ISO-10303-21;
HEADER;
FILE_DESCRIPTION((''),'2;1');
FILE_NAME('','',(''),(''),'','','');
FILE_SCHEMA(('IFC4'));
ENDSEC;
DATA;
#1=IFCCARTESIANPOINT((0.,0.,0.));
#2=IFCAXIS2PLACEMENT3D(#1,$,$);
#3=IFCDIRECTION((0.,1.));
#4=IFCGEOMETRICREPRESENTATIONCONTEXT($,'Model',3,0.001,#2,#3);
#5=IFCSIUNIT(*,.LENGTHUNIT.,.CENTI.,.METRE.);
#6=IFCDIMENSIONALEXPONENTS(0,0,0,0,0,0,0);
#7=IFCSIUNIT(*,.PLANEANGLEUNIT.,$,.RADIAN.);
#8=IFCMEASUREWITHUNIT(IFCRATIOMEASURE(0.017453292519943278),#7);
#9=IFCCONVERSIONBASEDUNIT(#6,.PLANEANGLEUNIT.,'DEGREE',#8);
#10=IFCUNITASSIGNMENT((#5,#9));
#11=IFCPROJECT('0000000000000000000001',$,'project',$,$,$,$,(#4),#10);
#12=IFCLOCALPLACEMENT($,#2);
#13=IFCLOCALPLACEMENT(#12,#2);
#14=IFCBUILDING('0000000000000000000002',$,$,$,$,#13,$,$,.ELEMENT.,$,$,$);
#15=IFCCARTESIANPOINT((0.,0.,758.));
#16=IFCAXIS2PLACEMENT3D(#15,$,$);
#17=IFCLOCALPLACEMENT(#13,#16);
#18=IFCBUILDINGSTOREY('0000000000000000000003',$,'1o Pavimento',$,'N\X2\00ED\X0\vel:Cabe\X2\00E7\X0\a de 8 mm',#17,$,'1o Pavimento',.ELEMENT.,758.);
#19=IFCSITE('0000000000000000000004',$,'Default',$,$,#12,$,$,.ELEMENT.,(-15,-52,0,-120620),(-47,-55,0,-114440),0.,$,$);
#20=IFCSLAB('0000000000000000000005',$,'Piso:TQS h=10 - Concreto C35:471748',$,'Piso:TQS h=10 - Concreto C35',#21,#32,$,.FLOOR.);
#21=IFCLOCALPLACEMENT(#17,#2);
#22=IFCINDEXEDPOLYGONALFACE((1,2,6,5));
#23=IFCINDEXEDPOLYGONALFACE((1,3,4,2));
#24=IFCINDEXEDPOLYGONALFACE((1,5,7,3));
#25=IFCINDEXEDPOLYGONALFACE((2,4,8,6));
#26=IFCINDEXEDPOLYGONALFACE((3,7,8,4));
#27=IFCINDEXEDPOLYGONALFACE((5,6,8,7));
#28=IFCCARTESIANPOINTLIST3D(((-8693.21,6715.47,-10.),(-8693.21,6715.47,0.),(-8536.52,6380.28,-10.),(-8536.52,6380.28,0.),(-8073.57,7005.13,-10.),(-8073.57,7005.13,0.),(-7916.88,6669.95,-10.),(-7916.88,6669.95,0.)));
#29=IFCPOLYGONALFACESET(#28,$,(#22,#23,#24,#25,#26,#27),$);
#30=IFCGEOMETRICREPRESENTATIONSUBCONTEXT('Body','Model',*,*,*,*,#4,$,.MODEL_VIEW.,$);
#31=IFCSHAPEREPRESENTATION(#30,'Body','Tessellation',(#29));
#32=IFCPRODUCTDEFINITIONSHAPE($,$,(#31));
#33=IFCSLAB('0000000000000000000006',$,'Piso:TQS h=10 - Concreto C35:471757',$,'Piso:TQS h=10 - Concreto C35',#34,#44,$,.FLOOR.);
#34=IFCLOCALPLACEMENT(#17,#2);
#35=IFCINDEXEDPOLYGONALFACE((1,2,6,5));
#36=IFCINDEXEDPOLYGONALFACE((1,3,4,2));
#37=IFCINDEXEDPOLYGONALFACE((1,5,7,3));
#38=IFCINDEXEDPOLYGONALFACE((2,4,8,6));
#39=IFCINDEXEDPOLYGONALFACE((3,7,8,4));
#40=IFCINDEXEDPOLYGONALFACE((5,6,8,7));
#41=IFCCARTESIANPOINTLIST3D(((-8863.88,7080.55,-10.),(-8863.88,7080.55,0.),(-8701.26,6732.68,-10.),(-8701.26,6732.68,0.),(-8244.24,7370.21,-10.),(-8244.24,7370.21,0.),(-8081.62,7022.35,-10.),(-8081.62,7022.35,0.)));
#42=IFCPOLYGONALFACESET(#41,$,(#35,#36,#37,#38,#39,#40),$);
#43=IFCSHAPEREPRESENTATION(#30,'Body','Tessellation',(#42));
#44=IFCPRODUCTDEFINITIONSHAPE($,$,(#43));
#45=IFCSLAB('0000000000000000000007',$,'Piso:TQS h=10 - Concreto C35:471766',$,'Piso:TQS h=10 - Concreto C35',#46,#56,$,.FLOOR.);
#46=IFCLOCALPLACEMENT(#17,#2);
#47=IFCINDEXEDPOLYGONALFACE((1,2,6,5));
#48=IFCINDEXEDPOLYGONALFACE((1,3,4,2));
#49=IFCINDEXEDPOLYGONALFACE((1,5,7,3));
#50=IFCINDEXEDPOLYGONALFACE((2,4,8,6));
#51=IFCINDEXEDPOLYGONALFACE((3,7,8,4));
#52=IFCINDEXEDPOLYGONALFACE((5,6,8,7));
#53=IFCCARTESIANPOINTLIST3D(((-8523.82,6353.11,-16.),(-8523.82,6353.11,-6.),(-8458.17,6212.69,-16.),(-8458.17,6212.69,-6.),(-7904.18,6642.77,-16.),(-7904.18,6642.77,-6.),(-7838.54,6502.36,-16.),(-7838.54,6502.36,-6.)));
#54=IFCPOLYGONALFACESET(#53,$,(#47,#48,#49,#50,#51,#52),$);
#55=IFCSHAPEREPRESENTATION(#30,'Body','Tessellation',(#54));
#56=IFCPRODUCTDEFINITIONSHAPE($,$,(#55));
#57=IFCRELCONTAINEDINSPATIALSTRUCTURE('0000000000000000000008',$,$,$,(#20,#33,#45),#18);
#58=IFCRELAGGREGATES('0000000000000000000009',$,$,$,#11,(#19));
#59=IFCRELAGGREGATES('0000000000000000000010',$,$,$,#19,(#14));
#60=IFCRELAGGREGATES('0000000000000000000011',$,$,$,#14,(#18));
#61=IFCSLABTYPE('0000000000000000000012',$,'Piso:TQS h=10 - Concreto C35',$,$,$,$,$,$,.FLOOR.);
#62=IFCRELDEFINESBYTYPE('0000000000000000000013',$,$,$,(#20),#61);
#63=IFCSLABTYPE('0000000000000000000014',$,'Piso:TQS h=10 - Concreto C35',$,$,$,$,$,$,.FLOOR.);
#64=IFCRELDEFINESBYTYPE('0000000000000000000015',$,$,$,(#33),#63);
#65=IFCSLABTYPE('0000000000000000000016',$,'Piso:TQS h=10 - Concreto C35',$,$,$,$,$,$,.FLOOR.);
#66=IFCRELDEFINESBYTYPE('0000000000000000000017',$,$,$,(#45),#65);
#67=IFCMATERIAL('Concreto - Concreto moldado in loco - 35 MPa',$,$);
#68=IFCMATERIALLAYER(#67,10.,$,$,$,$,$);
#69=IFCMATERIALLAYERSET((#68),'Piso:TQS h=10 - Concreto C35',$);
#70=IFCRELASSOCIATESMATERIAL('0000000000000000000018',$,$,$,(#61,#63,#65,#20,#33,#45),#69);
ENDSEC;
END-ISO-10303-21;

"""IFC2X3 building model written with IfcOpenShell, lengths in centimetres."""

from ifc_helpers import new_model, entity, si_unit, converted_unit, direction, frame, frame_2d, origin, place, context, subcontext, project, spatial, rectangle, extrude, material, layer, layer_set, layer_usage, type_object, element, save


model = new_model("IFC2X3")

# Units and contexts
model_context = context("Model", 3, precision=0.001, world=origin(), true_north=direction((0.0, 1.0)))
body_context = subcontext(model_context, "Body", "Model", "MODEL_VIEW")
ifc_project = project(units=[si_unit("LENGTHUNIT", "METRE", prefix="CENTI"), converted_unit("PLANEANGLEUNIT", "DEGREE", entity("IfcRatioMeasure", 0.017453292519943278), si_unit("PLANEANGLEUNIT", "RADIAN"), dimensions=[0, 0, 0, 0, 0, 0, 0])], contexts=[model_context])

# Site, building, storey
site_placement = place(None, origin())
site = spatial("IfcSite", under=ifc_project, at=site_placement, Name="Default", CompositionType="ELEMENT", RefLatitude=(-15, -52, 0, -120620), RefLongitude=(-47, -55, 0, -114440), RefElevation=0.0)
building_placement = place(site_placement, origin())
building = spatial("IfcBuilding", under=site, at=building_placement, CompositionType="ELEMENT")
storey_placement = place(building_placement, frame((0.0, 0.0, 758.0)))
storey = spatial("IfcBuildingStorey", under=building, at=storey_placement, Name="1o Pavimento", ObjectType="Nível:Cabeça de 8 mm", LongName="1o Pavimento", CompositionType="ELEMENT", Elevation=758.0)

# Shared definitions
ifc_material = material(Name="Concreto - Concreto moldado in loco - 35 MPa")

# Slabs
ifc_layer_1 = layer(ifc_material, 10.0)
ifc_layer_set_1 = layer_set([ifc_layer_1], Name="Piso:TQS h=10 - Concreto C35")
ifc_layer_usage_1 = layer_usage(ifc_layer_set_1, "AXIS3", "POSITIVE", 0.0)
slab_type_1 = type_object("IfcSlabType", Name="Piso:TQS h=10 - Concreto C35", PredefinedType="FLOOR", material=ifc_layer_set_1)
slab_1_placement = place(storey_placement, origin())
element("IfcSlab", 1, at=slab_1_placement, inside=storey, type_object=slab_type_1, material=ifc_layer_usage_1, Name="Piso:TQS h=10 - Concreto C35:471748", ObjectType="Piso:TQS h=10 - Concreto C35", PredefinedType="FLOOR", context=body_context, shape_type="SweptSolid", body=[
    extrude(rectangle(XDim=684.0, YDim=370.0, at=frame_2d((0.0, 0.0), x_axis=(1.0, 0.0))), frame((-8305.05, 6692.71, 0.0), z_axis=(0.0, 0.0, -1.0), x_axis=(0.905902, 0.423488, 0.0)), (0.0, 0.0, 1.0), 10.0),
])
ifc_layer_usage_2 = layer_usage(ifc_layer_set_1, "AXIS3", "POSITIVE", 0.0)
slab_type_2 = type_object("IfcSlabType", Name="Piso:TQS h=10 - Concreto C35", PredefinedType="FLOOR", material=ifc_layer_set_1)
slab_2_placement = place(storey_placement, origin())
element("IfcSlab", 2, at=slab_2_placement, inside=storey, type_object=slab_type_2, material=ifc_layer_usage_2, Name="Piso:TQS h=10 - Concreto C35:471757", ObjectType="Piso:TQS h=10 - Concreto C35", PredefinedType="FLOOR", context=body_context, shape_type="SweptSolid", body=[
    extrude(rectangle(XDim=684.0, YDim=384.0, at=frame_2d((0.0, 0.0), x_axis=(1.0, 0.0))), frame((-8472.75, 7051.45, 0.0), z_axis=(0.0, 0.0, -1.0), x_axis=(0.905902, 0.423488, 0.0)), (0.0, 0.0, 1.0), 10.0),
])
ifc_layer_usage_3 = layer_usage(ifc_layer_set_1, "AXIS3", "POSITIVE", 0.0)
slab_type_3 = type_object("IfcSlabType", Name="Piso:TQS h=10 - Concreto C35", PredefinedType="FLOOR", material=ifc_layer_set_1)
slab_3_placement = place(storey_placement, origin())
element("IfcSlab", 3, at=slab_3_placement, inside=storey, type_object=slab_type_3, material=ifc_layer_usage_3, Name="Piso:TQS h=10 - Concreto C35:471766", ObjectType="Piso:TQS h=10 - Concreto C35", PredefinedType="FLOOR", context=body_context, shape_type="SweptSolid", body=[
    extrude(rectangle(XDim=155.0, YDim=684.0, at=frame_2d((0.0, 0.0), x_axis=(1.0, 0.0))), frame((-8181.18, 6427.73, -6.0), z_axis=(0.0, 0.0, -1.0), x_axis=(0.423488, -0.905902, 0.0)), (0.0, 0.0, 1.0), 10.0),
])

save(model, "model.ifc")
